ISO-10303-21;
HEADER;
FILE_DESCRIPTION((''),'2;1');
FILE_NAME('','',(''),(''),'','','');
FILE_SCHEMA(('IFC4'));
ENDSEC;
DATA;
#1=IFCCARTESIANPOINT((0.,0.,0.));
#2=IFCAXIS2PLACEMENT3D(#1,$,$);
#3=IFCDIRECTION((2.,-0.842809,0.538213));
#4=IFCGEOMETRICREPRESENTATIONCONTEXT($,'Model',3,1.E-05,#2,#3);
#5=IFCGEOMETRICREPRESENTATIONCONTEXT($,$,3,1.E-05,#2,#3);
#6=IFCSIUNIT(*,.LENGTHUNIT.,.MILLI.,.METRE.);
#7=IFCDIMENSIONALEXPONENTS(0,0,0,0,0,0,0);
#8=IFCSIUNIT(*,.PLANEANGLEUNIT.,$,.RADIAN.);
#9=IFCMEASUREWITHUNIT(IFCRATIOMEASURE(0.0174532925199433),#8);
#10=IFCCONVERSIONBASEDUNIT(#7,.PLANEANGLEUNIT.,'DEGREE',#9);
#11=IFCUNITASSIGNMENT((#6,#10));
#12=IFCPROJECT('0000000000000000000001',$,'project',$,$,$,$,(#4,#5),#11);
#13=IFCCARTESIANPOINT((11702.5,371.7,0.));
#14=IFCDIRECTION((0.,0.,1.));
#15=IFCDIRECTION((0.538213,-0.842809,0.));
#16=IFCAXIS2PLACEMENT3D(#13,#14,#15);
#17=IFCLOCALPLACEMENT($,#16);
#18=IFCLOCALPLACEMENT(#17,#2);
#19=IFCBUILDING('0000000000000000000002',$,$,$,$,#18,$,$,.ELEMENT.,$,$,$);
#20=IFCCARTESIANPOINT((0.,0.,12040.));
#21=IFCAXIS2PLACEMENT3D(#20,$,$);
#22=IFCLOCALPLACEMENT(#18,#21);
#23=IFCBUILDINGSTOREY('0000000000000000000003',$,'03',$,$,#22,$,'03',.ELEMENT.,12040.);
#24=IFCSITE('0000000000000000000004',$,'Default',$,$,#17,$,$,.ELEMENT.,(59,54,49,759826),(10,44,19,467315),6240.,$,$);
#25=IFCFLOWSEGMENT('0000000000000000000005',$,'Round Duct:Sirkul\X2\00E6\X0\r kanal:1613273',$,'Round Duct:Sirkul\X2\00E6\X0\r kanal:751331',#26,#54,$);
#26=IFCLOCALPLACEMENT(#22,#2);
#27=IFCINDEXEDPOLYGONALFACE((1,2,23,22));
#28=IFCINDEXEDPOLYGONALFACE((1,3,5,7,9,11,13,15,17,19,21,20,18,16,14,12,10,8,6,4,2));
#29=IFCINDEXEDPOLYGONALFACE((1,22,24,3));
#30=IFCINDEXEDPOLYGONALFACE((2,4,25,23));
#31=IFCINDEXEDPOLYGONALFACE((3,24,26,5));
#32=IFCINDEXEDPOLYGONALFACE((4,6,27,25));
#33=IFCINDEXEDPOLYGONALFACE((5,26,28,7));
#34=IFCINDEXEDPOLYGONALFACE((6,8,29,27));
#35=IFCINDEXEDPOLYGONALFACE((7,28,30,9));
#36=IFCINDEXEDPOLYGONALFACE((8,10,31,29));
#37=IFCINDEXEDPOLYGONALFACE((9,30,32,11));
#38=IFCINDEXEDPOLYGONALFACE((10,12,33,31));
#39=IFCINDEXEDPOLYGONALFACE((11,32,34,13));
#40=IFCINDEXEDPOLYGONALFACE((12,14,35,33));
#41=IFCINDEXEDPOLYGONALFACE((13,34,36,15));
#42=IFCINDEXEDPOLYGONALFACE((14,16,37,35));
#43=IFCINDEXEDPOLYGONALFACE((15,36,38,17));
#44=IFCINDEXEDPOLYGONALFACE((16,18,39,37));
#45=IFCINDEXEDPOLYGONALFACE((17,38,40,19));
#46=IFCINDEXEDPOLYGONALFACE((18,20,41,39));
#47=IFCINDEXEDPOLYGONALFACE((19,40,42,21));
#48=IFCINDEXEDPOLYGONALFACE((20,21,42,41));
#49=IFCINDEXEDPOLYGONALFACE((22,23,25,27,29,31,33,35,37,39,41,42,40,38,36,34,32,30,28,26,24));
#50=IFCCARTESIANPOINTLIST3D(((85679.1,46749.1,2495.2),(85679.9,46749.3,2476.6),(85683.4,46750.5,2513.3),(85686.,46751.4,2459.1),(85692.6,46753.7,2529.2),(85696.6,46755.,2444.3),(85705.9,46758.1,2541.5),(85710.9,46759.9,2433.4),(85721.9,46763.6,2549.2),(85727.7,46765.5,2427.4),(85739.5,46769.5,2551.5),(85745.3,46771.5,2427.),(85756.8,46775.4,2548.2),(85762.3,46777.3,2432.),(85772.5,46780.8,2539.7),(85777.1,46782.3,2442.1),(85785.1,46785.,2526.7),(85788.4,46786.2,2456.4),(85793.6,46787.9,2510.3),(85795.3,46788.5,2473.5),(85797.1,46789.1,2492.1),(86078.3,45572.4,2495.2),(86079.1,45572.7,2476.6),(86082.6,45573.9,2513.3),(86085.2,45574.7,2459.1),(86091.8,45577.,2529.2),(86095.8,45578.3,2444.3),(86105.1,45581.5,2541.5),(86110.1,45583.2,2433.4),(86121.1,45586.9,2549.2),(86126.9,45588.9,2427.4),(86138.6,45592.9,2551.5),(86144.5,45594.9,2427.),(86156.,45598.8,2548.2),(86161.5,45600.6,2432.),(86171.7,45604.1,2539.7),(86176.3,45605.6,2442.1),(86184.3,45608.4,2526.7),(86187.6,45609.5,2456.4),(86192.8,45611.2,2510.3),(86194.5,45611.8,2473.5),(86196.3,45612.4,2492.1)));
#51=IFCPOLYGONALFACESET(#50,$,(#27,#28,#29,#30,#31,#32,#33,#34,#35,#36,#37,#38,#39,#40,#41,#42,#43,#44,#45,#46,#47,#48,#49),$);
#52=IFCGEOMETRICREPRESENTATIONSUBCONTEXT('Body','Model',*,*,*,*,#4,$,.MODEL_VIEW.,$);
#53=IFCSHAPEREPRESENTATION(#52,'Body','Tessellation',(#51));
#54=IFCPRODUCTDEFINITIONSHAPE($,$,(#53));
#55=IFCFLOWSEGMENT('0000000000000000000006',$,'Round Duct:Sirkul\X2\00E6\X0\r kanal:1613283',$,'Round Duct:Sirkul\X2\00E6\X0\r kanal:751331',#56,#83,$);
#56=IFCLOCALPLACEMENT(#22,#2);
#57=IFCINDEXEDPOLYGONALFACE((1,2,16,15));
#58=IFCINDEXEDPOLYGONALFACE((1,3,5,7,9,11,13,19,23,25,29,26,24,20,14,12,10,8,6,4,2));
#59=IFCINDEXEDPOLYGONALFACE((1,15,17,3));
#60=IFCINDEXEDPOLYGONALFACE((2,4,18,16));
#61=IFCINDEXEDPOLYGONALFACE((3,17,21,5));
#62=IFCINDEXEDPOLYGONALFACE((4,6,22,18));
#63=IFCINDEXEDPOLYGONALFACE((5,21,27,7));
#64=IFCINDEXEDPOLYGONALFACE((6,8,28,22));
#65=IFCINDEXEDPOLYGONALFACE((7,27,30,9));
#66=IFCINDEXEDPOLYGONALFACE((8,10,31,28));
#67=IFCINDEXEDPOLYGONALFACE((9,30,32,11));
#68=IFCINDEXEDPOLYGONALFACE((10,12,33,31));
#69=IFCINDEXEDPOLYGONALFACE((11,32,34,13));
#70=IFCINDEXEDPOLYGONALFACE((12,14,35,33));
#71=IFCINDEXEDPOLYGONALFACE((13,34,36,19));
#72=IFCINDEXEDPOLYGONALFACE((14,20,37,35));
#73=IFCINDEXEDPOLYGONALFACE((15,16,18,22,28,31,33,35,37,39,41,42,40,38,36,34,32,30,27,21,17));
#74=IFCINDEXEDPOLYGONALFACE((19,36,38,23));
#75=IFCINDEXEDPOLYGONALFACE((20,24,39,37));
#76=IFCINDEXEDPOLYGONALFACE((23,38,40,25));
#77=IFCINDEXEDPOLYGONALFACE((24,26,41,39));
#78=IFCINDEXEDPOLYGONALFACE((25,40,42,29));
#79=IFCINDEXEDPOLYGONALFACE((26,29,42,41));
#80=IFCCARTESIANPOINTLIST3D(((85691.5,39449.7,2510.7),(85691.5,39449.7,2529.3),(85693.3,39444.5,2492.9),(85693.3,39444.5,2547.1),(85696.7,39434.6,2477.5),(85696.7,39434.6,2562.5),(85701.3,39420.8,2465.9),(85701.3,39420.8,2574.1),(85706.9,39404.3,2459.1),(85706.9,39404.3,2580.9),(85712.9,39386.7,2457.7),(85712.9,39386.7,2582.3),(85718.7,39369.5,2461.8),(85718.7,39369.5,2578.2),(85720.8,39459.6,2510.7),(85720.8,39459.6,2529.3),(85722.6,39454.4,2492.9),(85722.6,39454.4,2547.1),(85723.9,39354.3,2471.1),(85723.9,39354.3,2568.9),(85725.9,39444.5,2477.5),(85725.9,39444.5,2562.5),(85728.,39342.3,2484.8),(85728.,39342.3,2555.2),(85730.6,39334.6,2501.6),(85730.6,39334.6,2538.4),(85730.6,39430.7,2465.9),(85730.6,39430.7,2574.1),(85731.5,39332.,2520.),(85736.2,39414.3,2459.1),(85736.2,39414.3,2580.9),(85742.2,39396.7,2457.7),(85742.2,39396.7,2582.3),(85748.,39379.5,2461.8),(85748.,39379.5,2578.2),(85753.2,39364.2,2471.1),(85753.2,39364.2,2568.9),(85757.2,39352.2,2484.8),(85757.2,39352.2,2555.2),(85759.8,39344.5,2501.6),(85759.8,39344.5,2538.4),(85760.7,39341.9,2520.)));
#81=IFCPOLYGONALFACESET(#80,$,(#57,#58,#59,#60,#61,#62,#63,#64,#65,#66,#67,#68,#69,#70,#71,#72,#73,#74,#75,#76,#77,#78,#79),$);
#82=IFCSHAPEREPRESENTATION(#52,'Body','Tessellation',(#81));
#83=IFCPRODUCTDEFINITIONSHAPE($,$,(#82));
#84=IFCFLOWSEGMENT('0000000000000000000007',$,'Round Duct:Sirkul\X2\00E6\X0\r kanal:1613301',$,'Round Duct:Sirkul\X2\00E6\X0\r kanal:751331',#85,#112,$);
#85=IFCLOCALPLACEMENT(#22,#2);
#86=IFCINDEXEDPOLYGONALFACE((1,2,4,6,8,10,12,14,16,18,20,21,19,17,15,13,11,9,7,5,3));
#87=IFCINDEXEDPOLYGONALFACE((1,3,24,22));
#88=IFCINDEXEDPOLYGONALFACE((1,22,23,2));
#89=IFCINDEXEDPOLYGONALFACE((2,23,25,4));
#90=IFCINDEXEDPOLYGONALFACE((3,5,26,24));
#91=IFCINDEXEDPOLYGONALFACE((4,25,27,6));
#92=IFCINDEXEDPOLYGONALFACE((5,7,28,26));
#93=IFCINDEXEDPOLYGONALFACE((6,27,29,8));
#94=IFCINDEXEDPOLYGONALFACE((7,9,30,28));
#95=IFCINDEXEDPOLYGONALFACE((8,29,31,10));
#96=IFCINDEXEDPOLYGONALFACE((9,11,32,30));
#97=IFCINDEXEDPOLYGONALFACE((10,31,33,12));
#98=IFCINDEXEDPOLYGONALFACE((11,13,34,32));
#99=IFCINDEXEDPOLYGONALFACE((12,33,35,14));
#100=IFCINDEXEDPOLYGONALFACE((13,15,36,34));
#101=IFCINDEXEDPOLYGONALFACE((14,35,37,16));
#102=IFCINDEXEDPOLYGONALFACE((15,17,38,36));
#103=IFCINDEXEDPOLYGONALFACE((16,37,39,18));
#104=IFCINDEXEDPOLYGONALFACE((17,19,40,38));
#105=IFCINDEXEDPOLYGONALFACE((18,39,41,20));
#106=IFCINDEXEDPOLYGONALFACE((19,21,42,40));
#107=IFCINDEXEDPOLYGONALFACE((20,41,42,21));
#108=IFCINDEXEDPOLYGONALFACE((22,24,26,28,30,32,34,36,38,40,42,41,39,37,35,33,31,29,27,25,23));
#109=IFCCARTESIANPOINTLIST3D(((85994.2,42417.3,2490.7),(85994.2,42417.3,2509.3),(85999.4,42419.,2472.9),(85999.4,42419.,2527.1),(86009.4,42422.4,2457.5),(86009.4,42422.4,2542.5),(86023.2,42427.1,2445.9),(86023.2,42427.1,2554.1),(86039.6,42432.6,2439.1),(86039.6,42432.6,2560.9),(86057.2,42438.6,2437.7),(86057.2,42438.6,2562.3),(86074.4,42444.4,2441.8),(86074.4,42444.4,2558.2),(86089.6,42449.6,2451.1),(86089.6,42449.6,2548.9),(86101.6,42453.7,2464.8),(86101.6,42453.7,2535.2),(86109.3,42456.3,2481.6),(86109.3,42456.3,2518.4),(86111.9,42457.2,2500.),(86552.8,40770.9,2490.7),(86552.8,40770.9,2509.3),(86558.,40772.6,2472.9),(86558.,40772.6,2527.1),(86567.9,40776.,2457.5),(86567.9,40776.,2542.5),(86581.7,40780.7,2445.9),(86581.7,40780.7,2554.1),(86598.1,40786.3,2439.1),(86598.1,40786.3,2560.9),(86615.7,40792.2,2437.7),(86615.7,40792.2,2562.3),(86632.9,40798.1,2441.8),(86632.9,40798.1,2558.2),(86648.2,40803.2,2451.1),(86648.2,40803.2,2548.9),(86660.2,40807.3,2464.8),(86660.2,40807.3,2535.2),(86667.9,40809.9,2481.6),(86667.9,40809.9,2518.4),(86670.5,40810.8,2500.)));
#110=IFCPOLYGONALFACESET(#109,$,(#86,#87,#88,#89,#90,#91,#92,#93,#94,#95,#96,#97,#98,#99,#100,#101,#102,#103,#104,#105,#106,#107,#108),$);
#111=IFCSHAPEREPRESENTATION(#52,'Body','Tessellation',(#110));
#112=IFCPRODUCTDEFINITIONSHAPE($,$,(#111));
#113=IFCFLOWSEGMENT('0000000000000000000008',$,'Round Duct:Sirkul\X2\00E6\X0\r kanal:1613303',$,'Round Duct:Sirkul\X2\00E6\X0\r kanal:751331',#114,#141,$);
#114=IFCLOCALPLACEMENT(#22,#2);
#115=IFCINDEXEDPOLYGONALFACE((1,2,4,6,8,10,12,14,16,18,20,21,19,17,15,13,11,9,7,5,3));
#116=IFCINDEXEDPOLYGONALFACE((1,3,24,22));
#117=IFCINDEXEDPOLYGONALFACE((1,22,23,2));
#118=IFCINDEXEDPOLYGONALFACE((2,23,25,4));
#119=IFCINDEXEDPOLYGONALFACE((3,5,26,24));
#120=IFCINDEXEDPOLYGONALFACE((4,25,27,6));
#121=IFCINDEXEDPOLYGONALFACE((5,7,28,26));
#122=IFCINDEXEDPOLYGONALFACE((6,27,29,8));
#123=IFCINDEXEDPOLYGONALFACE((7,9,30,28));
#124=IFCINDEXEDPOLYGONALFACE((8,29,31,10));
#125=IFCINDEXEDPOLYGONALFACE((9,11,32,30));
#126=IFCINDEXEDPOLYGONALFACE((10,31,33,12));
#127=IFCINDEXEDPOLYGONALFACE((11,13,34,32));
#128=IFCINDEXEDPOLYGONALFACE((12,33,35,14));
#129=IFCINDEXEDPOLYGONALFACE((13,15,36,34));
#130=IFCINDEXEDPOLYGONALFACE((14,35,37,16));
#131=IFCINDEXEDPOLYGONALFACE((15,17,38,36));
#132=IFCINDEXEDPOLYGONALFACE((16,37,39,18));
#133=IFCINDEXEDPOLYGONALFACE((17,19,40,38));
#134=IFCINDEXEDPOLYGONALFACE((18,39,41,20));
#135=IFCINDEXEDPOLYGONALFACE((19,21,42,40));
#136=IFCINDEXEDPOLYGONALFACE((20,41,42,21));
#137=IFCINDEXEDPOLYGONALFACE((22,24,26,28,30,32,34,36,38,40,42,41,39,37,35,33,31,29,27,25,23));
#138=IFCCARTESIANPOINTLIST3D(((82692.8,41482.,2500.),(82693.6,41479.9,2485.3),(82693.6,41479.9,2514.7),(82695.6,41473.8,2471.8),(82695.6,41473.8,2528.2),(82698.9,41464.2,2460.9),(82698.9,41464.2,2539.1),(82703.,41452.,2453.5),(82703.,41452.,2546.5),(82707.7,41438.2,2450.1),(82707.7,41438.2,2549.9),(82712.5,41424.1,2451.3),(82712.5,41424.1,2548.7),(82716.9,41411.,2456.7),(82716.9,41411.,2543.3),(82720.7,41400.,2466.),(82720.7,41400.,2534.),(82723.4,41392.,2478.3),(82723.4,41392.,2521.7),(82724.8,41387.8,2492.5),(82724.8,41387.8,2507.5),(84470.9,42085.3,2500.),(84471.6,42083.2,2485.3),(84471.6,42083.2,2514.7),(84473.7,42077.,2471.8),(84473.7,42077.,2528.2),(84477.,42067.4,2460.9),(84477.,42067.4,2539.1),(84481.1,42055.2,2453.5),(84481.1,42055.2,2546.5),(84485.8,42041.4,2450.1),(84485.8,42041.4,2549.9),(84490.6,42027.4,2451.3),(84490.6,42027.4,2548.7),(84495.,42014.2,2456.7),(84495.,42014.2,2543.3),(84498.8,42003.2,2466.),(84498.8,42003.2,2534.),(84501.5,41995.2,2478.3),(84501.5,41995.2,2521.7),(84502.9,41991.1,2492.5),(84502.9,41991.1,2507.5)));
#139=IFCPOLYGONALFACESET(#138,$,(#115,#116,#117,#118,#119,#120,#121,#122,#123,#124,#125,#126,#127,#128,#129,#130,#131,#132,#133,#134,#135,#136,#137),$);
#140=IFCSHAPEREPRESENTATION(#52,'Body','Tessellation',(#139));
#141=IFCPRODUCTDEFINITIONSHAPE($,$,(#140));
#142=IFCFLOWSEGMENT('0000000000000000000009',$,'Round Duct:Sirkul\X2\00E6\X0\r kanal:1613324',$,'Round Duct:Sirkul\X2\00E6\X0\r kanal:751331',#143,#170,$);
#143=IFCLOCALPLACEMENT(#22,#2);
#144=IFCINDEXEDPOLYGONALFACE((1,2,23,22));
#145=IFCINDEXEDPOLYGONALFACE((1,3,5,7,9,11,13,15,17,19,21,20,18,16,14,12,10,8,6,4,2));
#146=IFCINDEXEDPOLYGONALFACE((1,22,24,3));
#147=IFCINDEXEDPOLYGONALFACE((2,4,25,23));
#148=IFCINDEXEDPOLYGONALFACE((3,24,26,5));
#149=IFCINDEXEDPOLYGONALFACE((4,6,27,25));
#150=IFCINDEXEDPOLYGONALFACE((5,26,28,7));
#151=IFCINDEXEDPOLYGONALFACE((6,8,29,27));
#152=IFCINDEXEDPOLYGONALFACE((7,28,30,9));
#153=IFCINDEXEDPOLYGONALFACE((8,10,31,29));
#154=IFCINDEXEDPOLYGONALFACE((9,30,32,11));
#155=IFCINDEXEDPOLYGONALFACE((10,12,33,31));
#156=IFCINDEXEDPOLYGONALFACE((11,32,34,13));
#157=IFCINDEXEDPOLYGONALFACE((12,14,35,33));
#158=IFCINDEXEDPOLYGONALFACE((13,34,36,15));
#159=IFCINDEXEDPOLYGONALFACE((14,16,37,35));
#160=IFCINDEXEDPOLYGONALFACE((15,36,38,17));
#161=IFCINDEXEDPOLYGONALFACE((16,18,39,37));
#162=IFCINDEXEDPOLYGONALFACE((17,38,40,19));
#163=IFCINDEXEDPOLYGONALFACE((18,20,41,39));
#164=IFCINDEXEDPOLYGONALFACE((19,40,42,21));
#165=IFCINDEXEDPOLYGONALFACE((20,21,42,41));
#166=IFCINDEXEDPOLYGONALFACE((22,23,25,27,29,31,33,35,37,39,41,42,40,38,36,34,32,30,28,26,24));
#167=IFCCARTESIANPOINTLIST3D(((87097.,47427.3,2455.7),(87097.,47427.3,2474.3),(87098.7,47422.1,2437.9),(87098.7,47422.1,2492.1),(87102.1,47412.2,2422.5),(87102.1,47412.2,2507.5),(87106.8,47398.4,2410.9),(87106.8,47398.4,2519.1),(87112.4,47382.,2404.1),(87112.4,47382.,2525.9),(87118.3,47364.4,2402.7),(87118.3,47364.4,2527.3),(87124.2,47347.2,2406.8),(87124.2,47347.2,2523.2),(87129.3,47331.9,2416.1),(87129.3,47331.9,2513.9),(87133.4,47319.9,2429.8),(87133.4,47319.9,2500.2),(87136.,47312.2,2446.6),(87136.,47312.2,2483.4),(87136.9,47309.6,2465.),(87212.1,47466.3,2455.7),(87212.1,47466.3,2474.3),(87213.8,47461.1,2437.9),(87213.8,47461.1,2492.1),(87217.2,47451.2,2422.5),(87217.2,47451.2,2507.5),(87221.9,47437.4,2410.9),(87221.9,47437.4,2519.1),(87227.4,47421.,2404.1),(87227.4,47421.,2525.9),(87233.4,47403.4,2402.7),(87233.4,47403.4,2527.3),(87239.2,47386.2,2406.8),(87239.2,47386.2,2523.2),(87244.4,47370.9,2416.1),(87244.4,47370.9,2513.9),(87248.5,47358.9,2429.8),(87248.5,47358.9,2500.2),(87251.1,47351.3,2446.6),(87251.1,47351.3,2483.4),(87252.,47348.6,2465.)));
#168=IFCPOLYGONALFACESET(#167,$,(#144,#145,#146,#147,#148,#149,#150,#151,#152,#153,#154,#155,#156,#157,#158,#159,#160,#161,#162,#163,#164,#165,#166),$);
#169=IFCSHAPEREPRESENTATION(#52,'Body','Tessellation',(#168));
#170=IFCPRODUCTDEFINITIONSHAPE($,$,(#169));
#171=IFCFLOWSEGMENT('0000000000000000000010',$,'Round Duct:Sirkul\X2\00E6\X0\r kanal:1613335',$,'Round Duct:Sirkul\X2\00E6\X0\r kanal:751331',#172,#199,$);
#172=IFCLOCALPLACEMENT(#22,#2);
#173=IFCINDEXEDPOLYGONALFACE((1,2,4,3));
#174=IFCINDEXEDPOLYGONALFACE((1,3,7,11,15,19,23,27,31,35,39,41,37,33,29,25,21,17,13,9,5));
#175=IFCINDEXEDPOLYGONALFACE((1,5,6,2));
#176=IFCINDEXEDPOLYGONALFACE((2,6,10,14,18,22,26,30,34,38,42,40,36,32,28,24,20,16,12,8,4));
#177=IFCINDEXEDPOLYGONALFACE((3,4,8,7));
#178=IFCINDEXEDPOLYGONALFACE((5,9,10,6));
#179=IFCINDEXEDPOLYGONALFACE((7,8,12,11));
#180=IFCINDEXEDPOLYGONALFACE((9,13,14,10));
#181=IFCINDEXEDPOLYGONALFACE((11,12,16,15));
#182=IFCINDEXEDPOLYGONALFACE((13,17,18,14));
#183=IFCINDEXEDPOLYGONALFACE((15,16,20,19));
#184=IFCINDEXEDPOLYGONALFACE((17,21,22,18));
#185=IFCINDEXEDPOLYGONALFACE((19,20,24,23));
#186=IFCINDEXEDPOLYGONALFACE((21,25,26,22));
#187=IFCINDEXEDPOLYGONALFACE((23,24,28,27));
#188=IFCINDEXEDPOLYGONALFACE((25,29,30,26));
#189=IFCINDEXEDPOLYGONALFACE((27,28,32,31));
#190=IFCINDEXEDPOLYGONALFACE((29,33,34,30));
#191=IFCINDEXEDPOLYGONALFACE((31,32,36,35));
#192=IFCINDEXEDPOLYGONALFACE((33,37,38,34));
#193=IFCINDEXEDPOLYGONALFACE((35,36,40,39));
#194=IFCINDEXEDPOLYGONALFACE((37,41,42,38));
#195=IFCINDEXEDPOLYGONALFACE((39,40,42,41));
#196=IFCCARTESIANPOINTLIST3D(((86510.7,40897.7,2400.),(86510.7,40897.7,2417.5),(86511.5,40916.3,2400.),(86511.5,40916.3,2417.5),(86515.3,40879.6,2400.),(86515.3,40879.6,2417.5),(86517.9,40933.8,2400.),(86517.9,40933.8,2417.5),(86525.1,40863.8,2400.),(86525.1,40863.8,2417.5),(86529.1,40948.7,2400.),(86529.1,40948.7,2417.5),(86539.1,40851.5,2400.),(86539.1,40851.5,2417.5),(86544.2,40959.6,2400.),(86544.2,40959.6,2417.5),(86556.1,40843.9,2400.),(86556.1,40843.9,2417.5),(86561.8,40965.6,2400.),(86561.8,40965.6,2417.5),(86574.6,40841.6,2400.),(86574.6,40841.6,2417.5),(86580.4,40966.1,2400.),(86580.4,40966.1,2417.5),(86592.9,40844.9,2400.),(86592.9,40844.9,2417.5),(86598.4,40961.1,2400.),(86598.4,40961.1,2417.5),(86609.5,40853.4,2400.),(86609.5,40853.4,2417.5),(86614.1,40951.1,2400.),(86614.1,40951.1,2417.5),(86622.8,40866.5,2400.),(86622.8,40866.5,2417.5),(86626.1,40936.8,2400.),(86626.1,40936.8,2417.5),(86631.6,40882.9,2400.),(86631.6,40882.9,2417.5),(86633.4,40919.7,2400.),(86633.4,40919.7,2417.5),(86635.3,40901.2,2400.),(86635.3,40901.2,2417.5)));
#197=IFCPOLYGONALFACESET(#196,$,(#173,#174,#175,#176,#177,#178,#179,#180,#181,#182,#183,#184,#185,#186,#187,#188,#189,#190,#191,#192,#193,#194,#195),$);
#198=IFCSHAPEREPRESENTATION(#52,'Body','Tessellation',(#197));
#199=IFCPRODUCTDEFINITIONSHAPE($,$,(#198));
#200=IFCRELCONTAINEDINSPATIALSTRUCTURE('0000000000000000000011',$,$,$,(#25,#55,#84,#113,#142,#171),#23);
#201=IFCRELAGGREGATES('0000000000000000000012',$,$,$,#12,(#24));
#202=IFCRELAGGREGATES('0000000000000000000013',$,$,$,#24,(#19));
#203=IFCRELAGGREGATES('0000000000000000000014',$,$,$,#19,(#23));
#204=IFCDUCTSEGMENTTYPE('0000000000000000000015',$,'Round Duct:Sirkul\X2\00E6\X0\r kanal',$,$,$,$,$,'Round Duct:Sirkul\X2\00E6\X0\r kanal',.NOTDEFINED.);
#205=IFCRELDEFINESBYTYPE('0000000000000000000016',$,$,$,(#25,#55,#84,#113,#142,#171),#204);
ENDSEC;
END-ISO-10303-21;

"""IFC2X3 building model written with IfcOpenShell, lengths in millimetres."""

from ifc_helpers import new_model, entity, si_unit, converted_unit, direction, frame, frame_2d, origin, origin_2d_with_axis, place, context, subcontext, project, spatial, circle, extrude, type_object, element, save


model = new_model("IFC2X3")

# Units and contexts
model_context = context("Model", 3, precision=1e-05, world=origin(), true_north=direction((2.0, -0.842809, 0.538213)))
context_of_model = context(None, 3, precision=1e-05, world=origin(), true_north=direction((2.0, -0.842809, 0.538213)))
body_context = subcontext(model_context, "Body", "Model", "MODEL_VIEW")
ifc_project = project(units=[si_unit("LENGTHUNIT", "METRE", prefix="MILLI"), converted_unit("PLANEANGLEUNIT", "DEGREE", entity("IfcRatioMeasure", 0.0174532925199433), si_unit("PLANEANGLEUNIT", "RADIAN"), dimensions=[0, 0, 0, 0, 0, 0, 0])], contexts=[model_context, context_of_model])

# Site, building, storey
site_placement = place(None, frame((11702.5, 371.7, 0.0), z_axis=(0.0, 0.0, 1.0), x_axis=(0.538213, -0.842809, 0.0)))
site = spatial("IfcSite", under=ifc_project, at=site_placement, Name="Default", CompositionType="ELEMENT", RefLatitude=(59, 54, 49, 759826), RefLongitude=(10, 44, 19, 467315), RefElevation=6240.0)
building_placement = place(site_placement, origin())
building = spatial("IfcBuilding", under=site, at=building_placement, CompositionType="ELEMENT")
storey_placement = place(building_placement, frame((0.0, 0.0, 12040.0)))
storey = spatial("IfcBuildingStorey", under=building, at=storey_placement, Name="03", LongName="03", CompositionType="ELEMENT", Elevation=12040.0)

# Flow segments
duct_segment_type = type_object("IfcDuctSegmentType", Name="Round Duct:Sirkulær kanal", ElementType="Round Duct:Sirkulær kanal", PredefinedType="NOTDEFINED")
flow_segment_1_placement = place(storey_placement, origin())
element("IfcFlowSegment", 1, at=flow_segment_1_placement, inside=storey, type_object=duct_segment_type, Name="Round Duct:Sirkulær kanal:1613273", ObjectType="Round Duct:Sirkulær kanal:751331", context=body_context, shape_type="SweptSolid", body=[
    extrude(circle(Radius=62.5, at=frame_2d((0.0, 0.0), x_axis=(1.0, 0.0))), frame((85738.0, 46769.0, 2489.0), z_axis=(0.321274, -0.946986, 0.0), x_axis=(0.945827, 0.320881, 0.049463)), (0.0, 0.0, 1.0), 1242.5),
])
flow_segment_2_placement = place(storey_placement, origin())
element("IfcFlowSegment", 2, at=flow_segment_2_placement, inside=storey, type_object=duct_segment_type, Name="Round Duct:Sirkulær kanal:1613283", ObjectType="Round Duct:Sirkulær kanal:751331", context=body_context, shape_type="SweptSolid", body=[
    extrude(circle(Radius=62.5, at=frame_2d((0.0, 0.0), x_axis=(1.0, 0.0))), frame((85711.4, 39391.2, 2520.0), z_axis=(0.946986, 0.321274, 0.0), x_axis=(0.321274, -0.946986, 0.0)), (0.0, 0.0, 1.0), 30.9),
])
flow_segment_3_placement = place(storey_placement, origin())
element("IfcFlowSegment", 3, at=flow_segment_3_placement, inside=storey, type_object=duct_segment_type, Name="Round Duct:Sirkulær kanal:1613301", ObjectType="Round Duct:Sirkulær kanal:751331", context=body_context, shape_type="SweptSolid", body=[
    extrude(circle(Radius=62.5, at=origin_2d_with_axis()), frame((86052.7, 42437.1, 2500.0), z_axis=(0.321274, -0.946986, 0.0), x_axis=(0.946986, 0.321274, 0.0)), (0.0, 0.0, 1.0), 1738.5),
])
flow_segment_4_placement = place(storey_placement, origin())
element("IfcFlowSegment", 4, at=flow_segment_4_placement, inside=storey, type_object=duct_segment_type, Name="Round Duct:Sirkulær kanal:1613303", ObjectType="Round Duct:Sirkulær kanal:751331", context=body_context, shape_type="SweptSolid", body=[
    extrude(circle(Radius=50.0, at=origin_2d_with_axis()), frame((82708.9, 41434.7, 2500.0), z_axis=(0.946986, 0.321276, 0.0), x_axis=(-0.321276, 0.946986, 0.0)), (0.0, 0.0, 1.0), 1877.6),
])
flow_segment_5_placement = place(storey_placement, origin())
element("IfcFlowSegment", 5, at=flow_segment_5_placement, inside=storey, type_object=duct_segment_type, Name="Round Duct:Sirkulær kanal:1613324", ObjectType="Round Duct:Sirkulær kanal:751331", context=body_context, shape_type="SweptSolid", body=[
    extrude(circle(Radius=62.5, at=origin_2d_with_axis()), frame((87116.8, 47368.8, 2465.0), z_axis=(0.946996, 0.321245, 0.0), x_axis=(0.321245, -0.946996, 0.0)), (0.0, 0.0, 1.0), 121.5),
])
flow_segment_6_placement = place(storey_placement, origin())
element("IfcFlowSegment", 6, at=flow_segment_6_placement, inside=storey, type_object=duct_segment_type, Name="Round Duct:Sirkulær kanal:1613335", ObjectType="Round Duct:Sirkulær kanal:751331", context=body_context, shape_type="SweptSolid", body=[
    extrude(circle(Radius=62.5, at=origin_2d_with_axis()), frame((86572.8, 40904.1, 2400.0), z_axis=(0.0, 0.0, 1.0), x_axis=(0.321274, -0.946986, 0.0)), (0.0, 0.0, 1.0), 17.5),
])

save(model, "model.ifc")
